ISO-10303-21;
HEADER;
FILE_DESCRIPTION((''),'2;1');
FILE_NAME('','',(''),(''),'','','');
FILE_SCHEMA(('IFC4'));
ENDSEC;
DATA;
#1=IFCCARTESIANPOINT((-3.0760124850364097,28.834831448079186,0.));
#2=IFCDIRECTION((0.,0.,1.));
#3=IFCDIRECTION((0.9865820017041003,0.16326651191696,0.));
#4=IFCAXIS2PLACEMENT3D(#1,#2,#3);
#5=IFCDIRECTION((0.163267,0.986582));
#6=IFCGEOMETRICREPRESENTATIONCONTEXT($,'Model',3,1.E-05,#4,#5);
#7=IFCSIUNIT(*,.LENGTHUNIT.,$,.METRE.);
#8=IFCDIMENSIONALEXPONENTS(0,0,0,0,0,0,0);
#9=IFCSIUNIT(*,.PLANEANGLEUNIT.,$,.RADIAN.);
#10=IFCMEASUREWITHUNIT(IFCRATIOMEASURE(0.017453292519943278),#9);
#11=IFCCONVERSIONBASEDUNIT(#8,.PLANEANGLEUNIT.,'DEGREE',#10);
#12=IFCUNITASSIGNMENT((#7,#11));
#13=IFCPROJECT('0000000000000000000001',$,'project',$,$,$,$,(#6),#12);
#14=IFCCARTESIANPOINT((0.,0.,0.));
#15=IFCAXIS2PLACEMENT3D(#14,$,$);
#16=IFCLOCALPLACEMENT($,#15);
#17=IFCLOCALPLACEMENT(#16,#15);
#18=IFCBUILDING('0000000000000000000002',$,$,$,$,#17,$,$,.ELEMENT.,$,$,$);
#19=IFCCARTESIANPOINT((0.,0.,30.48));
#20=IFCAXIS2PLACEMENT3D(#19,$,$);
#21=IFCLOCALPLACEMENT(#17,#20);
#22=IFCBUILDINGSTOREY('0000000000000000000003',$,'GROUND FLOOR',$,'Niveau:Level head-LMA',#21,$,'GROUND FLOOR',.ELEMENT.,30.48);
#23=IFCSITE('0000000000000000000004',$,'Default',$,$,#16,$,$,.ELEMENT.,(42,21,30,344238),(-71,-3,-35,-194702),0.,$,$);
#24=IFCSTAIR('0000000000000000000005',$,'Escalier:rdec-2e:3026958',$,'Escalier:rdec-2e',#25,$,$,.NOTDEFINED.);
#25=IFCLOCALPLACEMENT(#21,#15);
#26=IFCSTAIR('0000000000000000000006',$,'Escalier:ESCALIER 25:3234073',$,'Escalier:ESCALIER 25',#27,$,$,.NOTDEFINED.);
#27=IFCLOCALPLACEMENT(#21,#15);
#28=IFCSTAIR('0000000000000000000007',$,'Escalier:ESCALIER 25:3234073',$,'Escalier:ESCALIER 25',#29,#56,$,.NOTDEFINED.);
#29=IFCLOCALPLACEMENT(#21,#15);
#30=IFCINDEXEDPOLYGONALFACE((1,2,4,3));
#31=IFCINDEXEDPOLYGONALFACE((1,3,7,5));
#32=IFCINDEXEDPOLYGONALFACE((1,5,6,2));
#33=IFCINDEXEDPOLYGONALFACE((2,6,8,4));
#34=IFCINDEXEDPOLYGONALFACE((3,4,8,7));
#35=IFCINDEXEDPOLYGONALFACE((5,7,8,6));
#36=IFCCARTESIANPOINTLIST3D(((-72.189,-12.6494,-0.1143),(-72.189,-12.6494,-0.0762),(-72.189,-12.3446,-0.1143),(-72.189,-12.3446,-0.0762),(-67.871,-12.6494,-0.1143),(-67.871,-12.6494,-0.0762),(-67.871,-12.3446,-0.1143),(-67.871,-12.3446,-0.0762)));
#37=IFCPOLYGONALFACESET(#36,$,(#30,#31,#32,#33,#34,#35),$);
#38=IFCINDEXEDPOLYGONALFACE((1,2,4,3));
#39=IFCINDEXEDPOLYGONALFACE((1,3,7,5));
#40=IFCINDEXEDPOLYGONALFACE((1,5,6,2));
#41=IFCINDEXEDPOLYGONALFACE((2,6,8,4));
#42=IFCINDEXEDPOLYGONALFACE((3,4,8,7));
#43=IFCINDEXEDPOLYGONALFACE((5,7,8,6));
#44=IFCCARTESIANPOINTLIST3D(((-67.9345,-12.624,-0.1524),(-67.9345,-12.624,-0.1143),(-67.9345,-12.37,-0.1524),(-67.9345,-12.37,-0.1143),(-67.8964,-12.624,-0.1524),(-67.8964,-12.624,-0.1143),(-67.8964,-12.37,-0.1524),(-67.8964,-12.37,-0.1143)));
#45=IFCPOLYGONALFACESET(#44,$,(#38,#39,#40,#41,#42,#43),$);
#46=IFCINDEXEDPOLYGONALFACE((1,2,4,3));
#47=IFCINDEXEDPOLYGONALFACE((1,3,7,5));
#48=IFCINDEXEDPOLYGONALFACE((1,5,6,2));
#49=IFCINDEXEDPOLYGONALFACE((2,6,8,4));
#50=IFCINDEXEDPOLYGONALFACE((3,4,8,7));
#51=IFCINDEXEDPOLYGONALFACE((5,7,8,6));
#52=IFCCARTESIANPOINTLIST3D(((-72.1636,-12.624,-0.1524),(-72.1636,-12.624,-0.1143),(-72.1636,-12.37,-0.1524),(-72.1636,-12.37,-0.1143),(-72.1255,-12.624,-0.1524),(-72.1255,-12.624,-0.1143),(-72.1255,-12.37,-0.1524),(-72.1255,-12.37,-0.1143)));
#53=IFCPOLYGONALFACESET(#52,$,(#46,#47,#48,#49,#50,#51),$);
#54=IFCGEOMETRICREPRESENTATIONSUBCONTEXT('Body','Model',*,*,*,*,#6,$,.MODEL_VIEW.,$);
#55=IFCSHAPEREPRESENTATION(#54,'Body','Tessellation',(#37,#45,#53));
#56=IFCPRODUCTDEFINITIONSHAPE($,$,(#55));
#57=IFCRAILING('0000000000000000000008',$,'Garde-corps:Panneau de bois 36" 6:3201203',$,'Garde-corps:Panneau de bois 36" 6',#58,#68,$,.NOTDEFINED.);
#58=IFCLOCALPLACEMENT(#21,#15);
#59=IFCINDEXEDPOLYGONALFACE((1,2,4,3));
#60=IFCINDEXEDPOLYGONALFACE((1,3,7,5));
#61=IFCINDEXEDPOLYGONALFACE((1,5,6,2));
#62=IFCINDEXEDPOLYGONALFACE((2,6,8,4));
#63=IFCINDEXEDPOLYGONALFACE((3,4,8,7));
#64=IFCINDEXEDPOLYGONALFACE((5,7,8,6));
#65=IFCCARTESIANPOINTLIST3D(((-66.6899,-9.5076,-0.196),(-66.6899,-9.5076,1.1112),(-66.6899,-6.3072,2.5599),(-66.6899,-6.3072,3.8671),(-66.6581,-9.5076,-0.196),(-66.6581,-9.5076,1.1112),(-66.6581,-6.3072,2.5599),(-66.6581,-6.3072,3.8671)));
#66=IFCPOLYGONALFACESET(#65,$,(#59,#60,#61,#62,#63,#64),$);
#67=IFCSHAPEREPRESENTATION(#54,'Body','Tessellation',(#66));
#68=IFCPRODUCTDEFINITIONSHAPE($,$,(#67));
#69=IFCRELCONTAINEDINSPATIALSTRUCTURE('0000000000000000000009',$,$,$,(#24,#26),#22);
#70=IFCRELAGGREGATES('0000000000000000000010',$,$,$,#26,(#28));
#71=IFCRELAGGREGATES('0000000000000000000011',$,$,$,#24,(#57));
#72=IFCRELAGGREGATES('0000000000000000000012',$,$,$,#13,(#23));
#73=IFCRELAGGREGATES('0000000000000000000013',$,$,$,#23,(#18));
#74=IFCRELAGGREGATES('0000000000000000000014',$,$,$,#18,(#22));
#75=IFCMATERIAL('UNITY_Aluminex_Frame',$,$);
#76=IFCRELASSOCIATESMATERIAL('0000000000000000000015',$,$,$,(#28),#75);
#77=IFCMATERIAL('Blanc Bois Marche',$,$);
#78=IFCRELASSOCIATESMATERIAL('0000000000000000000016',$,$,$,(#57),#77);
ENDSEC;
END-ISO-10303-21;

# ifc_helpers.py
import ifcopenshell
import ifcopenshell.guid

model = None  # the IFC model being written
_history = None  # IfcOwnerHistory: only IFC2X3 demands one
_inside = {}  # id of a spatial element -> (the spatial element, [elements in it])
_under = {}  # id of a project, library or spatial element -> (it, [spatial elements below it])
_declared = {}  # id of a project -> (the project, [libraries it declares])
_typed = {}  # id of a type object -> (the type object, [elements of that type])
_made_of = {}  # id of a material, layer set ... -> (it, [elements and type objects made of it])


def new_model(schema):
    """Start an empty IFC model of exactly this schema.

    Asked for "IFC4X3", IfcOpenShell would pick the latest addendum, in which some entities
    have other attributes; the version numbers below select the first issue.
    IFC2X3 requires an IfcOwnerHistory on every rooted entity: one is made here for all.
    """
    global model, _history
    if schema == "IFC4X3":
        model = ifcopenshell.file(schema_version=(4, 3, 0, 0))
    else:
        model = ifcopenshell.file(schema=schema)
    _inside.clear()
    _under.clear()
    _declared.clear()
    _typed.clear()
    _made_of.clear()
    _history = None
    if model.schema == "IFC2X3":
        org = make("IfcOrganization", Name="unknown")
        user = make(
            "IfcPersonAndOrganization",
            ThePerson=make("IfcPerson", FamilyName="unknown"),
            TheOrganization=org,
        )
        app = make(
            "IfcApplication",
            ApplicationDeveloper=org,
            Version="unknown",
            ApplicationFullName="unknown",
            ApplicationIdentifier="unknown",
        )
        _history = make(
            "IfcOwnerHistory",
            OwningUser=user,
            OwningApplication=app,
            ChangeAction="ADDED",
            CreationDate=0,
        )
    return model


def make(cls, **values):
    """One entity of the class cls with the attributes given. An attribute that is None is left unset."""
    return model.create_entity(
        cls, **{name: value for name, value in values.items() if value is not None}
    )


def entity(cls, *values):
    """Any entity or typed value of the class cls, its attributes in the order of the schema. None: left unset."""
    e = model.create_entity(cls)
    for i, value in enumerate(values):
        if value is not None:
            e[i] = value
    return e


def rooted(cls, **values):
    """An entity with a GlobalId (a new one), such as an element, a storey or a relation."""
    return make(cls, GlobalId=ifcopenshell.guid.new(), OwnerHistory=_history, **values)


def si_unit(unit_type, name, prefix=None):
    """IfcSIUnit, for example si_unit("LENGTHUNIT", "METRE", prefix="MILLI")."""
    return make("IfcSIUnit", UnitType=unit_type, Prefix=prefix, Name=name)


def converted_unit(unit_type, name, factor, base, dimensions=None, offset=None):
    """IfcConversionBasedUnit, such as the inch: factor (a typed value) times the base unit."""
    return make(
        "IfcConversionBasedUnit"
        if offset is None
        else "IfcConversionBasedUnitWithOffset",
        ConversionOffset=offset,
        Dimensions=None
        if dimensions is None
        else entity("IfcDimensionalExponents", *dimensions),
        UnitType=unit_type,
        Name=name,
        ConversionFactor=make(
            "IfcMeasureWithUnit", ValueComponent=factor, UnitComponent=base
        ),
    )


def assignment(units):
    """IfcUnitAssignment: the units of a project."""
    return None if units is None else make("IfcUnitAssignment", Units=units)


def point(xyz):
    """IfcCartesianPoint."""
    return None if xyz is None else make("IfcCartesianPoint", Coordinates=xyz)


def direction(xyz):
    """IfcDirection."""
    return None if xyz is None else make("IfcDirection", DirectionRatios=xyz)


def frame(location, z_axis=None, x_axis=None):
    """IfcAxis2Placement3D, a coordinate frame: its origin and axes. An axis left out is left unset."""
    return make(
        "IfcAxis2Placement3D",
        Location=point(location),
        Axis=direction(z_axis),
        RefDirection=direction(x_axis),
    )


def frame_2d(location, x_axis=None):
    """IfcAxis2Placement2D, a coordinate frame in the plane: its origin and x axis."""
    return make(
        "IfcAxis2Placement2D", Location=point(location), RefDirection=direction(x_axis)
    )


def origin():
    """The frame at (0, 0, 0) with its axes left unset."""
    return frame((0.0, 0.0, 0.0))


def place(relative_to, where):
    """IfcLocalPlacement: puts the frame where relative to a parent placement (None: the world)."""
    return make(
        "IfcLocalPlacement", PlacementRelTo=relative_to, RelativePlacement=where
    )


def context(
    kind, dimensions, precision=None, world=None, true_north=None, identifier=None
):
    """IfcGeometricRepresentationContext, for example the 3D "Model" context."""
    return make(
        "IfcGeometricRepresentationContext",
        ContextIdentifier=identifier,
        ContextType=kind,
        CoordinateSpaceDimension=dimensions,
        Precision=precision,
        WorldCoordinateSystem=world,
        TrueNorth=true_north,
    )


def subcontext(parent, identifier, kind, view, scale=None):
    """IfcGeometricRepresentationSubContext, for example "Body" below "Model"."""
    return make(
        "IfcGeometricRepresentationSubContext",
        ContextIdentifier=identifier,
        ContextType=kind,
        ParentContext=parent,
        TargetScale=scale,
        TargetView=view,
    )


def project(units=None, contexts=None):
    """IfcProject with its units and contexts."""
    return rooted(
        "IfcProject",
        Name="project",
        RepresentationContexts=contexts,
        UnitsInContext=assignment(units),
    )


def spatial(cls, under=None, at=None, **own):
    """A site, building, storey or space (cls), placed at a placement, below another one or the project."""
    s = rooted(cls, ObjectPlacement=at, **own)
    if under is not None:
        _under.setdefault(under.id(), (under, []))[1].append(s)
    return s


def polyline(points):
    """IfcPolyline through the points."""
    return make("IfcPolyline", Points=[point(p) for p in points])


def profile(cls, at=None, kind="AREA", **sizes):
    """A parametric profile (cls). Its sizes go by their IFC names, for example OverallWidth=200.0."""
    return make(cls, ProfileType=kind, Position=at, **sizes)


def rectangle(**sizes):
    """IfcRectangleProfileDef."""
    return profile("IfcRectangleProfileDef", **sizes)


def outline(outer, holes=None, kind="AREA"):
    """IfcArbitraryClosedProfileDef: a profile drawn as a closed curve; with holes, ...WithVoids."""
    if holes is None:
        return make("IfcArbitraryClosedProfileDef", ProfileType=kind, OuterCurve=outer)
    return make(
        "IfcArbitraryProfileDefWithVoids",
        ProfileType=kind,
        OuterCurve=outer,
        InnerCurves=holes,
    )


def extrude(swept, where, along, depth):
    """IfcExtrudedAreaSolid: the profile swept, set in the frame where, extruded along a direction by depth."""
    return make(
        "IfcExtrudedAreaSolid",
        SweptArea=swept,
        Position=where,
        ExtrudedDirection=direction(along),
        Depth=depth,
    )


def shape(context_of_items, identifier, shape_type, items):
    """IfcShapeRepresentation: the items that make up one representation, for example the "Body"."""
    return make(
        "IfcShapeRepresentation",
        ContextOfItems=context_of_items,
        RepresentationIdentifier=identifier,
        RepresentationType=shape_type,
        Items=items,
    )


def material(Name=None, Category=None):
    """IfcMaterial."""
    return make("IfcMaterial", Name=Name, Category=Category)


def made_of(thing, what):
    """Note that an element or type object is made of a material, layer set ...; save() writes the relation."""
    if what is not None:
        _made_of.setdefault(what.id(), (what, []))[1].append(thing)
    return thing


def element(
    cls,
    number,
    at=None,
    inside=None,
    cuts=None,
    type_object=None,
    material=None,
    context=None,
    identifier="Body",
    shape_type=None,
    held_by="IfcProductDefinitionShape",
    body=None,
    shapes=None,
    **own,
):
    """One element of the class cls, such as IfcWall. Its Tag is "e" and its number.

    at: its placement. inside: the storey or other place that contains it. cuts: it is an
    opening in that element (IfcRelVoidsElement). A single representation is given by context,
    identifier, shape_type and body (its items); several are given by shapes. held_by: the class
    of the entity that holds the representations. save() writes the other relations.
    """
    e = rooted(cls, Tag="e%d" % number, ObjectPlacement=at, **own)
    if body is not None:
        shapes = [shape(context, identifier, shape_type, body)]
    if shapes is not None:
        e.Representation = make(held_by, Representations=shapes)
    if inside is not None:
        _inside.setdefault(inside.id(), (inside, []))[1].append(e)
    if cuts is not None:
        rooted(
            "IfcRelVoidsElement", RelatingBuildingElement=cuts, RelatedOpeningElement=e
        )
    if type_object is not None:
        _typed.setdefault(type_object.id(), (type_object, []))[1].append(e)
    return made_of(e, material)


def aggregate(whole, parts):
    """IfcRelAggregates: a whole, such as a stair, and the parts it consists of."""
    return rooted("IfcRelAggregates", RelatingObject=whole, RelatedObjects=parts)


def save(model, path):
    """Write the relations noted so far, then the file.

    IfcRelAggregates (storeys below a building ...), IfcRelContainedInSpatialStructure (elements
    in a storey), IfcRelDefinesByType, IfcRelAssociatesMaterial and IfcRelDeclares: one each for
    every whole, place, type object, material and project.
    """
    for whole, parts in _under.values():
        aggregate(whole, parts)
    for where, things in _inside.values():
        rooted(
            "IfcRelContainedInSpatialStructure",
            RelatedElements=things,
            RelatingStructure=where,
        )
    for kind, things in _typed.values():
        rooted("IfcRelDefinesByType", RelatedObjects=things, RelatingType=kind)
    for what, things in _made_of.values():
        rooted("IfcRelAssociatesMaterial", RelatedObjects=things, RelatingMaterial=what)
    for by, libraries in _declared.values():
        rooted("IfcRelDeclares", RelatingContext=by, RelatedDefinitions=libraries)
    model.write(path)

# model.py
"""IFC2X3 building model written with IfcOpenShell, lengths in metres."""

from ifc_helpers import new_model, entity, si_unit, converted_unit, direction, frame, frame_2d, origin, place, context, subcontext, project, spatial, polyline, rectangle, outline, extrude, material, element, aggregate, save


model = new_model("IFC2X3")

# Units and contexts
model_context = context("Model", 3, precision=1e-05, world=frame((-3.0760124850364097, 28.834831448079186, 0.0), z_axis=(0.0, 0.0, 1.0), x_axis=(0.9865820017041003, 0.16326651191696, 0.0)), true_north=direction((0.163267, 0.986582)))
body_context = subcontext(model_context, "Body", "Model", "MODEL_VIEW")
ifc_project = project(units=[si_unit("LENGTHUNIT", "METRE"), converted_unit("PLANEANGLEUNIT", "DEGREE", entity("IfcRatioMeasure", 0.017453292519943278), si_unit("PLANEANGLEUNIT", "RADIAN"), dimensions=[0, 0, 0, 0, 0, 0, 0])], contexts=[model_context])

# Site, building, storey
site_placement = place(None, origin())
site = spatial("IfcSite", under=ifc_project, at=site_placement, Name="Default", CompositionType="ELEMENT", RefLatitude=(42, 21, 30, 344238), RefLongitude=(-71, -3, -35, -194702), RefElevation=0.0)
building_placement = place(site_placement, origin())
building = spatial("IfcBuilding", under=site, at=building_placement, CompositionType="ELEMENT")
storey_placement = place(building_placement, frame((0.0, 0.0, 30.48)))
storey = spatial("IfcBuildingStorey", under=building, at=storey_placement, Name="GROUND FLOOR", ObjectType="Niveau:Level head-LMA", LongName="GROUND FLOOR", CompositionType="ELEMENT", Elevation=30.48)

# Stairs
stair_1_placement = place(storey_placement, origin())
stair_1 = element("IfcStair", 1, at=stair_1_placement, inside=storey, Name="Escalier:rdec-2e:3026958", ObjectType="Escalier:rdec-2e", ShapeType="NOTDEFINED")
stair_2_placement = place(storey_placement, origin())
stair_2 = element("IfcStair", 2, at=stair_2_placement, inside=storey, Name="Escalier:ESCALIER 25:3234073", ObjectType="Escalier:ESCALIER 25", ShapeType="NOTDEFINED")
ifc_material_1 = material(Name="UNITY_Aluminex_Frame")
stair_3_placement = place(stair_2_placement, origin())
stair_3 = element("IfcStair", 3, at=stair_3_placement, material=ifc_material_1, Name="Escalier:ESCALIER 25:3234073", ObjectType="Escalier:ESCALIER 25", ShapeType="NOTDEFINED", context=body_context, shape_type="SweptSolid", body=[
    extrude(rectangle(XDim=0.3048, YDim=4.318, at=frame_2d((0.0, 0.0), x_axis=(1.0, 0.0))), frame((-70.03, -12.497, -0.1143), z_axis=(0.0, 0.0, 1.0), x_axis=(0.0, -1.0, 0.0)), (0.0, 0.0, 1.0), 0.0381),
    extrude(rectangle(XDim=0.254, YDim=0.0381, at=frame_2d((0.0, 0.0), x_axis=(1.0, 0.0))), frame((-67.9154, -12.497, -0.1524), z_axis=(0.0, 0.0, 1.0), x_axis=(0.0, -1.0, 0.0)), (0.0, 0.0, 1.0), 0.0381),
    extrude(rectangle(XDim=0.254, YDim=0.0381, at=frame_2d((0.0, 0.0), x_axis=(1.0, 0.0))), frame((-72.1445, -12.497, -0.1524), z_axis=(0.0, 0.0, 1.0), x_axis=(0.0, -1.0, 0.0)), (0.0, 0.0, 1.0), 0.0381),
])
aggregate(stair_2, [stair_3])

# Railing
ifc_material_2 = material(Name="Blanc Bois Marche")
railing_placement = place(stair_1_placement, frame((0.0, 0.0, 2.8448)))
railing = element("IfcRailing", 4, at=railing_placement, material=ifc_material_2, Name="Garde-corps:Panneau de bois 36\" 6:3201203", ObjectType="Garde-corps:Panneau de bois 36\" 6", PredefinedType="NOTDEFINED", context=body_context, shape_type="SweptSolid", body=[
    extrude(outline(polyline([(-2.5382, -0.4953), (1.6852, -0.4953), (2.5382, 0.4953), (-1.6852, 0.4953), (-2.5382, -0.4953)])), frame((-66.6899, -7.9074, -1.0092), z_axis=(1.0, 0.0, 0.0), x_axis=(0.0, -0.757769, -0.652523)), (0.0, 0.0, 1.0), 0.0318),
])
aggregate(stair_1, [railing])

save(model, "model.ifc")
